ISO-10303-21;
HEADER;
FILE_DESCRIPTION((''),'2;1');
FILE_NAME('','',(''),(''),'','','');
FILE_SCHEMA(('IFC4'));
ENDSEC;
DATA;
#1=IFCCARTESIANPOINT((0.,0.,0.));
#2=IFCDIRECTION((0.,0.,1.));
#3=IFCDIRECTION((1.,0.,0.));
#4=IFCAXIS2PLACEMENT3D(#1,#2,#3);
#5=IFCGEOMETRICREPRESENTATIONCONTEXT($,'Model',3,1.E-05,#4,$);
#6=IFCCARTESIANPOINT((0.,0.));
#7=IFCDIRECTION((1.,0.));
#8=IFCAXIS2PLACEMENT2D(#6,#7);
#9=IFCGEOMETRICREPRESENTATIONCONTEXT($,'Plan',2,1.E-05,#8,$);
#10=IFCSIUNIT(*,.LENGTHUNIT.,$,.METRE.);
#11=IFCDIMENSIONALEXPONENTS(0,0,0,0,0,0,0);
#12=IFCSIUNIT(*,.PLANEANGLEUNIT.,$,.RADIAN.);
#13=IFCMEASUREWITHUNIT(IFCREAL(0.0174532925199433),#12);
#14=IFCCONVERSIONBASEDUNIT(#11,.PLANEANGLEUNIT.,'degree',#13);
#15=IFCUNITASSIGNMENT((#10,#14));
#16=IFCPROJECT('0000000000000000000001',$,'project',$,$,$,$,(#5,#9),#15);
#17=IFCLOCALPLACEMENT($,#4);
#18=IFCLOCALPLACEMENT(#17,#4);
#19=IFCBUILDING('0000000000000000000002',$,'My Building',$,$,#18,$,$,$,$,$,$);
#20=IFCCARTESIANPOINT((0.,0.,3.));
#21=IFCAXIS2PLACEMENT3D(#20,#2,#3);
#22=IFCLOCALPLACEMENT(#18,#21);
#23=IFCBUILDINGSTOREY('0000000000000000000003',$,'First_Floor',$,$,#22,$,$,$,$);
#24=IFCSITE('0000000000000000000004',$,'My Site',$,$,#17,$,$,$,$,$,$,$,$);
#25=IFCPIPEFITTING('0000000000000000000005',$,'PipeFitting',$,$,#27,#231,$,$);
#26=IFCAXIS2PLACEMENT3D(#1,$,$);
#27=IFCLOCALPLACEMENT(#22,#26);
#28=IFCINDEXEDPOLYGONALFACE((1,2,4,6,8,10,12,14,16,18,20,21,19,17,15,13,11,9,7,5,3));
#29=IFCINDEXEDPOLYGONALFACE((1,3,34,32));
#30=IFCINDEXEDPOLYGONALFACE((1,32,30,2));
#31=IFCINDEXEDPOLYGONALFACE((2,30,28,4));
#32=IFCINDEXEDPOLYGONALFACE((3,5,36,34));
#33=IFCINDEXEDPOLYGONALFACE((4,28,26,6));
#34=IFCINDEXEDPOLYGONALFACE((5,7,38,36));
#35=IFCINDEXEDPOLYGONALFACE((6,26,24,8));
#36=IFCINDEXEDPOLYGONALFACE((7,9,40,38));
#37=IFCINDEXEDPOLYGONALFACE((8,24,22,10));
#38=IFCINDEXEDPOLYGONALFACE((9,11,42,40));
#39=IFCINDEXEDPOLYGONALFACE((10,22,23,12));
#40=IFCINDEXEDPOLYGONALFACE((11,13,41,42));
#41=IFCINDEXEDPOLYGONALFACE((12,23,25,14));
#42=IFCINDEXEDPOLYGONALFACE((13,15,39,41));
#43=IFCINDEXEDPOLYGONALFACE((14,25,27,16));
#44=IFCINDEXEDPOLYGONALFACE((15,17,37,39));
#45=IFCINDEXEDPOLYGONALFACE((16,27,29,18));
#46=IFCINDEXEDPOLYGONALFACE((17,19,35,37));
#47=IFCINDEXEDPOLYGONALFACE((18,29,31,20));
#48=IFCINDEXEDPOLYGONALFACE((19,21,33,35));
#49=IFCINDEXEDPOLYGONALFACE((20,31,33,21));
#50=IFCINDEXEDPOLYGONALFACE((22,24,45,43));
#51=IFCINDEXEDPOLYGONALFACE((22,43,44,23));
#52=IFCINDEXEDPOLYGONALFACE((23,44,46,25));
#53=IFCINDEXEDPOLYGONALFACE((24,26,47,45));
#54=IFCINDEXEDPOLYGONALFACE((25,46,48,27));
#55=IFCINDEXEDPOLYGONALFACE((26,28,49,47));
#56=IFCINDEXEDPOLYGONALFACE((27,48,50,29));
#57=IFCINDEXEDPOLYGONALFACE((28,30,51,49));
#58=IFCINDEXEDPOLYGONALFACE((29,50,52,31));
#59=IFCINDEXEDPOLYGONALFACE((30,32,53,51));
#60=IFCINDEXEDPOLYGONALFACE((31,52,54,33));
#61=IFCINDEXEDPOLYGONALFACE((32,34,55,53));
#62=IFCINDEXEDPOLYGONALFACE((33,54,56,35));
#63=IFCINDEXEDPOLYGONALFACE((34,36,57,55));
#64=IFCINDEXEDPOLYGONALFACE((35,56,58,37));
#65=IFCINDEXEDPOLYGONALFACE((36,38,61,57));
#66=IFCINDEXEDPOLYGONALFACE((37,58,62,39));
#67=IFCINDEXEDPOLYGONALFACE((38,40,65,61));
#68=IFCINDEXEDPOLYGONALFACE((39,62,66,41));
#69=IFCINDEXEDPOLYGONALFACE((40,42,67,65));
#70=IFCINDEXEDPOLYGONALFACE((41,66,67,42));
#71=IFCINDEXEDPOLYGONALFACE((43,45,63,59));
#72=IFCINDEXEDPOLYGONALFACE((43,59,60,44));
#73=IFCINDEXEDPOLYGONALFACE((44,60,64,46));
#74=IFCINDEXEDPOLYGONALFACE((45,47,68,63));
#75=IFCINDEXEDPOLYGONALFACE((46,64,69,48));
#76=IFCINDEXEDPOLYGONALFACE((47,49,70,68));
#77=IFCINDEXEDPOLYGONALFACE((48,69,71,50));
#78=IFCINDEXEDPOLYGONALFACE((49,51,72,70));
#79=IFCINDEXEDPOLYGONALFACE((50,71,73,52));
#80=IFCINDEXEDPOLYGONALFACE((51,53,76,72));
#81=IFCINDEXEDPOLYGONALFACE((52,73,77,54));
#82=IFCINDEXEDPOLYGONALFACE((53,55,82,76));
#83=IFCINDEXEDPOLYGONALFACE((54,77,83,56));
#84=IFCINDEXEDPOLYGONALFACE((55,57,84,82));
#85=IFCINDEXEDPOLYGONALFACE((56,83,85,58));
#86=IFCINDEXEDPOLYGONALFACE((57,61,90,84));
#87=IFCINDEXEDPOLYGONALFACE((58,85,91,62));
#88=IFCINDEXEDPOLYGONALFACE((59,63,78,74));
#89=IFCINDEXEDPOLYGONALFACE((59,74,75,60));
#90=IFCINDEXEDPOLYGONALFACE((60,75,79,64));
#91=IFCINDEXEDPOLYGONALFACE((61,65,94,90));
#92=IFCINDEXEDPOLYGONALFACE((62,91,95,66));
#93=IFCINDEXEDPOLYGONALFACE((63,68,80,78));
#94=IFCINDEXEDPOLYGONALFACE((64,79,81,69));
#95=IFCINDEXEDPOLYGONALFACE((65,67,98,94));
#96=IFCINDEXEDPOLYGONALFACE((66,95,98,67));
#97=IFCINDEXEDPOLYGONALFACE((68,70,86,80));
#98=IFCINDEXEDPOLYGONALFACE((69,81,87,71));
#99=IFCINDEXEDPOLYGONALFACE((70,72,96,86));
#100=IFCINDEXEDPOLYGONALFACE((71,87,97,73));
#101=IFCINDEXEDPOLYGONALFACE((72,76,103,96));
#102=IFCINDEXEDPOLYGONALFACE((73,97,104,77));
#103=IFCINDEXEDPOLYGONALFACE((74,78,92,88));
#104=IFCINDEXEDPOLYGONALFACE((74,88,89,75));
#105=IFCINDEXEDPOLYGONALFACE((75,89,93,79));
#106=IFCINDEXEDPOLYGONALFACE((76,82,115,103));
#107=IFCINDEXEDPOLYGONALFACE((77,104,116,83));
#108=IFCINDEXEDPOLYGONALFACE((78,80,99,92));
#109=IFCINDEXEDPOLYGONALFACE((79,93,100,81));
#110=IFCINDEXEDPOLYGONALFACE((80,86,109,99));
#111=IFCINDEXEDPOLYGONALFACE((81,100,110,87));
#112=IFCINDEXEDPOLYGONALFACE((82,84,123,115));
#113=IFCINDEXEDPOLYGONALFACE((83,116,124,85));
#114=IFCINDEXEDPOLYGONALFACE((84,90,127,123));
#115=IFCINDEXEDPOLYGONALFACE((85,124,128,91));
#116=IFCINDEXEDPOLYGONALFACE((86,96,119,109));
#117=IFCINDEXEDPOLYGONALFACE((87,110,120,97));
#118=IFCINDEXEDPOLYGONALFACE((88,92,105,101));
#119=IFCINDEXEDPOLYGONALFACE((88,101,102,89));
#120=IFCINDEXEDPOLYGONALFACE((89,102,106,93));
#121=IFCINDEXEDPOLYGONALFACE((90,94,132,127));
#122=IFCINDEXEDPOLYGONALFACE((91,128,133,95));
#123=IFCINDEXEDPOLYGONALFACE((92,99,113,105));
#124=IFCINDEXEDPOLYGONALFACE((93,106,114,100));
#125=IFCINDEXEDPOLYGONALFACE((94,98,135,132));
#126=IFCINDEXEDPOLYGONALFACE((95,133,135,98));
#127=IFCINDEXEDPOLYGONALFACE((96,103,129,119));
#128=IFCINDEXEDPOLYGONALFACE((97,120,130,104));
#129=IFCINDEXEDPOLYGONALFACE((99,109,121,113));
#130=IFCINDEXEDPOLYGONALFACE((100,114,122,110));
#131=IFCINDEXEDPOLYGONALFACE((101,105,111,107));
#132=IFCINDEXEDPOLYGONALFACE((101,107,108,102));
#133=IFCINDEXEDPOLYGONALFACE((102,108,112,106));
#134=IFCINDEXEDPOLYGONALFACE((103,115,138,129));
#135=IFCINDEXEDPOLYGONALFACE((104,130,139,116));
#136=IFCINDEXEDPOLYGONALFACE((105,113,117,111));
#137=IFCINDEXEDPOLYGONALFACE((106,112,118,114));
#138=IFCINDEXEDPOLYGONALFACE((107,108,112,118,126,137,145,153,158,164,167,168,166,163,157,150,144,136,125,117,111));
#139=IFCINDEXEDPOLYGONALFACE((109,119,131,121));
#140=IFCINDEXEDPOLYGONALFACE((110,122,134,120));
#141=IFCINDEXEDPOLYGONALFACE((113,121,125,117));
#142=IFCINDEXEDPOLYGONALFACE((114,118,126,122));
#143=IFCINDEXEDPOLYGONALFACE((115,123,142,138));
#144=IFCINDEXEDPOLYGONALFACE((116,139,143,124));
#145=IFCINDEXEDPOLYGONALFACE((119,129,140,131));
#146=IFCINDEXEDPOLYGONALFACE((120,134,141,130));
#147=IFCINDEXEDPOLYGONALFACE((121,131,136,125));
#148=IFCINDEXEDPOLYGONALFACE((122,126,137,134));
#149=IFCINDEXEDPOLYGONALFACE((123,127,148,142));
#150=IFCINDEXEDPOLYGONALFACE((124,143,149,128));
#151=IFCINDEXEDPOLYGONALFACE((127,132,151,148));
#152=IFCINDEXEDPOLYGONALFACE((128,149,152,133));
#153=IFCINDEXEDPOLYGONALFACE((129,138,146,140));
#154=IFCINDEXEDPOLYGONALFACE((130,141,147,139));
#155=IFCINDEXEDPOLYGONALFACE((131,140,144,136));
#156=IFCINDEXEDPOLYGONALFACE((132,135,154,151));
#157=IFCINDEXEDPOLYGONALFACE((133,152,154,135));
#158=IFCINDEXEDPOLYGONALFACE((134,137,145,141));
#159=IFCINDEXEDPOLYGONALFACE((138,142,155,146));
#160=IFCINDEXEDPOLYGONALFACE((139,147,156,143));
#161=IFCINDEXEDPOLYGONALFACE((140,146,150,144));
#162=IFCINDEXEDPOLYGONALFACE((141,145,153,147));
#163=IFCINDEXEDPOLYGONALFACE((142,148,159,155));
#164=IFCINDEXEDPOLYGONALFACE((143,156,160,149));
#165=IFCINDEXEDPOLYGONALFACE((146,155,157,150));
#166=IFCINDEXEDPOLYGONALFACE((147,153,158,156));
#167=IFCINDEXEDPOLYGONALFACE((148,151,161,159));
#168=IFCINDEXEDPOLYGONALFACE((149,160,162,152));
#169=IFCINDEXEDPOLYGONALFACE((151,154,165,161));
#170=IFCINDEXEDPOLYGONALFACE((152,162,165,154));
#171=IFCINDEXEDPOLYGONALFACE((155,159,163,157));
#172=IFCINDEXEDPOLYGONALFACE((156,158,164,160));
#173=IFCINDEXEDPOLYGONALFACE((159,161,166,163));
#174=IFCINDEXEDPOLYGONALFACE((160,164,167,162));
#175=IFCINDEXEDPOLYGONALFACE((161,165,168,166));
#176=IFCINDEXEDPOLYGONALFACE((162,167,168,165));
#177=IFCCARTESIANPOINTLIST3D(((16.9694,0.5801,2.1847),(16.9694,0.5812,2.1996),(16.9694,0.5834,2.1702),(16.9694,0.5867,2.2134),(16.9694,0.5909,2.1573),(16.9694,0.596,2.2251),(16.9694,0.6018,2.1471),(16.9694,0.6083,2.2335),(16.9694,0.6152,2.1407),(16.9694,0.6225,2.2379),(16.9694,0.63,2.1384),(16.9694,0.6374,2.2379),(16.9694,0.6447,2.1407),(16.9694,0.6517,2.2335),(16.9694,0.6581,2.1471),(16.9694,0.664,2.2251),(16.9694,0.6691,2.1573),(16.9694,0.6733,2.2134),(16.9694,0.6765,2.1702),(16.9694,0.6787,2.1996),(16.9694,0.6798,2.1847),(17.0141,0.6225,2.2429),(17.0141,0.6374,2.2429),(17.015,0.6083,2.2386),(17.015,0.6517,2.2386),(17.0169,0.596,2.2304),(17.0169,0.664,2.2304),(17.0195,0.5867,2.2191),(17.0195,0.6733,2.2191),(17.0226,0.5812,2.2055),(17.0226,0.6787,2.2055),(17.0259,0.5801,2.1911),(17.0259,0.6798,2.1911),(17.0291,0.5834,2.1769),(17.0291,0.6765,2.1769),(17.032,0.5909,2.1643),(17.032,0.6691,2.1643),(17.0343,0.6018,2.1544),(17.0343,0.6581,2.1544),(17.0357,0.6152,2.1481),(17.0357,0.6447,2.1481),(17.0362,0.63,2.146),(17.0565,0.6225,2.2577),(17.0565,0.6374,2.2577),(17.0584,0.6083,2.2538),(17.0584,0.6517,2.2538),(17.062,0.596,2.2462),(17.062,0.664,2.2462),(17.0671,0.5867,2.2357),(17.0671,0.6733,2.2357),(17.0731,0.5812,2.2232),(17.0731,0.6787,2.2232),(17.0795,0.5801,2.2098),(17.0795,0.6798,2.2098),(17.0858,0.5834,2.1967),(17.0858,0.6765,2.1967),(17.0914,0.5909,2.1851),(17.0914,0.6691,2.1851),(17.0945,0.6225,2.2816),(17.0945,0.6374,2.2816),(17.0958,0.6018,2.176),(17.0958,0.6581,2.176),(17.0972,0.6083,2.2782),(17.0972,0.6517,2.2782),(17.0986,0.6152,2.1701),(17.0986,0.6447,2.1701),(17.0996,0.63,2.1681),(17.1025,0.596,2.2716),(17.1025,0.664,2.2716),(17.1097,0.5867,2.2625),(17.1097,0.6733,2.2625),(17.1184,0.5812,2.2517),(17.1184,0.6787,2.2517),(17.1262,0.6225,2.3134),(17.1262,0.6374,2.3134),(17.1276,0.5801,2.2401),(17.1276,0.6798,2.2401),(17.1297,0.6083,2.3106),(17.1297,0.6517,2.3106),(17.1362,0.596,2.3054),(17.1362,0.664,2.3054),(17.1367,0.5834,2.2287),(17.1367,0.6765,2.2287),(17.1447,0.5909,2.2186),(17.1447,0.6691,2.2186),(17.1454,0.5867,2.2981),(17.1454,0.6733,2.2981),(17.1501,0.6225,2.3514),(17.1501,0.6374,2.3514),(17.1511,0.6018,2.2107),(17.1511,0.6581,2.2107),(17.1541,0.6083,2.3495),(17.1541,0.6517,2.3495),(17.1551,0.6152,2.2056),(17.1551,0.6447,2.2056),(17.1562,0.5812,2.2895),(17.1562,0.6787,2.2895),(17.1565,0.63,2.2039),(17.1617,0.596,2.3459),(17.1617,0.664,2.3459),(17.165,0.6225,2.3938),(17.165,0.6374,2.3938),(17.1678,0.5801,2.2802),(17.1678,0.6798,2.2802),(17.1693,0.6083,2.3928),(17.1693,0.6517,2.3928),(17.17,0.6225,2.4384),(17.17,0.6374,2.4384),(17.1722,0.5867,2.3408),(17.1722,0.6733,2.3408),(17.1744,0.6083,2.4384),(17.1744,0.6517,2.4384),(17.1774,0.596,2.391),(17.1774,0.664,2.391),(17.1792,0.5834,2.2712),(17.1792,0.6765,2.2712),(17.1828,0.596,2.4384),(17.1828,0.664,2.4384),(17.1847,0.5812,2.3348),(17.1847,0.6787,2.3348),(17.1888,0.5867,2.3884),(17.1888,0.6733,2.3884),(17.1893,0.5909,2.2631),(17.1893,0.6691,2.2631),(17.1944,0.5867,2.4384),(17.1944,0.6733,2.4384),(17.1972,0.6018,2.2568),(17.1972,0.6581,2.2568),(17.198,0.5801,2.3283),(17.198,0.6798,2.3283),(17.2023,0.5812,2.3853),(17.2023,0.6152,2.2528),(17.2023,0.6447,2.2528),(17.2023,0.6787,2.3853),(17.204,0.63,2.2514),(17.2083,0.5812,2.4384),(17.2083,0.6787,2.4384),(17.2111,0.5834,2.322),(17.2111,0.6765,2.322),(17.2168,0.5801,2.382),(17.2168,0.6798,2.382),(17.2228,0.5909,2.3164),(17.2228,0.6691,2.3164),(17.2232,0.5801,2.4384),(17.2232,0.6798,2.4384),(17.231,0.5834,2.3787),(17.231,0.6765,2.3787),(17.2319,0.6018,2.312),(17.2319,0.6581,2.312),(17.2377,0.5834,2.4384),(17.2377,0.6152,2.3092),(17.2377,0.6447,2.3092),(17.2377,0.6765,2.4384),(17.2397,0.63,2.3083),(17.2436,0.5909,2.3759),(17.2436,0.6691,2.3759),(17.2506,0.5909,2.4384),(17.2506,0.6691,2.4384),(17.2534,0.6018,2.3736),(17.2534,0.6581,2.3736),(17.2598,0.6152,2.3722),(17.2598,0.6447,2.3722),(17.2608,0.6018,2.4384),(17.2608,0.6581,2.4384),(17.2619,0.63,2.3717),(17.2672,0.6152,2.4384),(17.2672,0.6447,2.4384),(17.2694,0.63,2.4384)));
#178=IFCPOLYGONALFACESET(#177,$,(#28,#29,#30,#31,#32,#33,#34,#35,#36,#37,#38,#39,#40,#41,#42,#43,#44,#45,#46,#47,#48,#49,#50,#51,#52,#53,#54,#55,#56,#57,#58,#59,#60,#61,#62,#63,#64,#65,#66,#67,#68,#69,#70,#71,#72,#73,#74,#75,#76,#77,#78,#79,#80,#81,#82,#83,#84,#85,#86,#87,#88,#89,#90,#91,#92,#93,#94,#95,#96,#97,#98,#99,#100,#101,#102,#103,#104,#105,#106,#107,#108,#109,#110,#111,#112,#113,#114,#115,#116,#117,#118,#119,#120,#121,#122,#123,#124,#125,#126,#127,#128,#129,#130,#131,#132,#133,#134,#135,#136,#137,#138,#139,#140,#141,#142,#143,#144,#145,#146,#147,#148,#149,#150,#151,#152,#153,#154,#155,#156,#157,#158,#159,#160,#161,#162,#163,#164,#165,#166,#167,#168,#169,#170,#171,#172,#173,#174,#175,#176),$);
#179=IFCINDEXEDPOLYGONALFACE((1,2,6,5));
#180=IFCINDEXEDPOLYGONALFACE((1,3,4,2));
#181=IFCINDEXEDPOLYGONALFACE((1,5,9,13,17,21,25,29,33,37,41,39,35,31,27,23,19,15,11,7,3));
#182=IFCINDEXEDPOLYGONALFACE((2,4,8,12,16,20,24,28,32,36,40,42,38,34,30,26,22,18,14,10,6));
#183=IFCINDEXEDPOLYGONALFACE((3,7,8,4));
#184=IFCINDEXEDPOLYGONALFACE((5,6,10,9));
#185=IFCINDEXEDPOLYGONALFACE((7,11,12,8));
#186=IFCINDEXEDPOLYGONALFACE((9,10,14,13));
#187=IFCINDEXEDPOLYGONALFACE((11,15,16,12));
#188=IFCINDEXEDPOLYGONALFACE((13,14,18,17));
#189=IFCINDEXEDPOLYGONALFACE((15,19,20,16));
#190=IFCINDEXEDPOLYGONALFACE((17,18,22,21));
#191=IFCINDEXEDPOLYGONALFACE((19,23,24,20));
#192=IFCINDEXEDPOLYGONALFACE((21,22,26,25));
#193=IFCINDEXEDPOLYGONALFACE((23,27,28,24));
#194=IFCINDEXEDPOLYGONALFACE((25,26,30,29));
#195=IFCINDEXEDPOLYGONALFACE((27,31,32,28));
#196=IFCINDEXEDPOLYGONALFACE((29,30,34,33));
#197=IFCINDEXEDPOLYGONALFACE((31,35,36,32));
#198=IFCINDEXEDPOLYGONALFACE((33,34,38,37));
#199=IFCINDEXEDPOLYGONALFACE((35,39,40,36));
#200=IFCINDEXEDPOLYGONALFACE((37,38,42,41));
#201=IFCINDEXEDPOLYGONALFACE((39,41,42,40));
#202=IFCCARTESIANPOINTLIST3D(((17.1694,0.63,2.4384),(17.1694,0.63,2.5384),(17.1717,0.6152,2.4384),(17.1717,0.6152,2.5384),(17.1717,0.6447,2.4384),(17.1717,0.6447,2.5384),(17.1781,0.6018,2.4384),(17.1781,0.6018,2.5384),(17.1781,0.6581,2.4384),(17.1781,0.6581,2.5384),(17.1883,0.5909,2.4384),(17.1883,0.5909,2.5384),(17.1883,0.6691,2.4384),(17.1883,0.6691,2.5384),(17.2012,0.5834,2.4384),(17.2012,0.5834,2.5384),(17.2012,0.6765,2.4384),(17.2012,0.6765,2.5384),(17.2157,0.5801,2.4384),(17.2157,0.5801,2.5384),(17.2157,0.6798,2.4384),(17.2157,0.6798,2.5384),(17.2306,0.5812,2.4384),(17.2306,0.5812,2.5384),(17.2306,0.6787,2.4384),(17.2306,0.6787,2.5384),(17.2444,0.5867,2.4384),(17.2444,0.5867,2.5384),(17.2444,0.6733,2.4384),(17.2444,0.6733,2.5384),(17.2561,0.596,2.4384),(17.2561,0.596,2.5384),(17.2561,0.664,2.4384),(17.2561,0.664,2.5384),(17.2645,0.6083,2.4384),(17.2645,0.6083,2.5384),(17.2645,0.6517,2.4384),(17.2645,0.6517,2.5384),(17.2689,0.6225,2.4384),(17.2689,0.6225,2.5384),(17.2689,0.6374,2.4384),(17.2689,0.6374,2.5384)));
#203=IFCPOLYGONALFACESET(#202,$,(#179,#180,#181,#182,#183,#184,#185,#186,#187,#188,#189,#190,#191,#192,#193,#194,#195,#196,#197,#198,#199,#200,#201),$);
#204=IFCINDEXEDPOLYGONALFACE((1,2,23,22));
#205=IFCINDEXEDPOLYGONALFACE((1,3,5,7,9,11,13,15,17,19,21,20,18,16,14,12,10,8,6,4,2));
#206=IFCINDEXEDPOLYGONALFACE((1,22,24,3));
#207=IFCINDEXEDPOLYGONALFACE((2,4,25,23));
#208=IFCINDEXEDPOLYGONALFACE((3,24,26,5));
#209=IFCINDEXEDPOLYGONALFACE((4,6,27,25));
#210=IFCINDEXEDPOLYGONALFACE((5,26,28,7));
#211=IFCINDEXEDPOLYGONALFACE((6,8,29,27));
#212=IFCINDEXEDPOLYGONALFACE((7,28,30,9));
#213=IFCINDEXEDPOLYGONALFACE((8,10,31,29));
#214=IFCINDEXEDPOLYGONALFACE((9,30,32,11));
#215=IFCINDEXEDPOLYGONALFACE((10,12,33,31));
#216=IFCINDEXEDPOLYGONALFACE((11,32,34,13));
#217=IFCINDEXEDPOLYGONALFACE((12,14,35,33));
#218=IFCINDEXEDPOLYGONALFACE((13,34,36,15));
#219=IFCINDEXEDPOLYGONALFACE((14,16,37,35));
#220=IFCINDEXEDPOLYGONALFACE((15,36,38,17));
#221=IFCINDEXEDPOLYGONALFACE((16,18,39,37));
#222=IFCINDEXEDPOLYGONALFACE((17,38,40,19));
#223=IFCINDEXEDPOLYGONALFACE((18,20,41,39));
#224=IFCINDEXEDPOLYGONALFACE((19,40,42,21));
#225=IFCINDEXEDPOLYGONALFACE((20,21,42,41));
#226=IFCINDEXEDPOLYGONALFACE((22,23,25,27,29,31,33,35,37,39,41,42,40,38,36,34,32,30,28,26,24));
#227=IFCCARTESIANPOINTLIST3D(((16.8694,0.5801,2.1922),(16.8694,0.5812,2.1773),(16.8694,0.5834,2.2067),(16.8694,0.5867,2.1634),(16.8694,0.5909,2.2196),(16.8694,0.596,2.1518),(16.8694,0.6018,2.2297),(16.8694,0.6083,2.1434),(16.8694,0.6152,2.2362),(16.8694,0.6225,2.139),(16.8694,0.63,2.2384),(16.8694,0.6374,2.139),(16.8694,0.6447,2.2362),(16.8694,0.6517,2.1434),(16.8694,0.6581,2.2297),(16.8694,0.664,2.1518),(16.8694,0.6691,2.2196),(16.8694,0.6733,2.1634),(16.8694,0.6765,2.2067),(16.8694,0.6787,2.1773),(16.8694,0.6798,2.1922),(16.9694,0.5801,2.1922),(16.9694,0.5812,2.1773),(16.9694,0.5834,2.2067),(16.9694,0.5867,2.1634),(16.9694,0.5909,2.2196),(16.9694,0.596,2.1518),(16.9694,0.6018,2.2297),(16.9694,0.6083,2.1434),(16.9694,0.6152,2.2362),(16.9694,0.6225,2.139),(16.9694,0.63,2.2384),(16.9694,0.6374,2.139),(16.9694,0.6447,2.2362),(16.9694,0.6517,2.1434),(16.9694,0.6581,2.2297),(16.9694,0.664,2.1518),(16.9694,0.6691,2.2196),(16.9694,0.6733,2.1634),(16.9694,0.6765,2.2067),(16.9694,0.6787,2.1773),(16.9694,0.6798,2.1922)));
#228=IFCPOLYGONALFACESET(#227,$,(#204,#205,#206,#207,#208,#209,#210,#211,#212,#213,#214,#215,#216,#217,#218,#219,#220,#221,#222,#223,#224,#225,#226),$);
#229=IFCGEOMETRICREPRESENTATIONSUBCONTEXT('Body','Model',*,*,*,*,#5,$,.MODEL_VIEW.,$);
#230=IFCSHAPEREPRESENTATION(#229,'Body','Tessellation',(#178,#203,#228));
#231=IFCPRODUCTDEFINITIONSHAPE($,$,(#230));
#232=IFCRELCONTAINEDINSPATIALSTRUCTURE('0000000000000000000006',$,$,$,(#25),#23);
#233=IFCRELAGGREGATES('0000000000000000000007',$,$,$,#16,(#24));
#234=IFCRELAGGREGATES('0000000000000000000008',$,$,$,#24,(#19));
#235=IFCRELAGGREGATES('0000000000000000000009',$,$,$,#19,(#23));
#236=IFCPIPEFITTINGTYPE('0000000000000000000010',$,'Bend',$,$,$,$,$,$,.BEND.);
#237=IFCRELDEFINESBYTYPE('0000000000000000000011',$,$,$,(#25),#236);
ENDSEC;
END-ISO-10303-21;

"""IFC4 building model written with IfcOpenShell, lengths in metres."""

from ifc_helpers import new_model, entity, si_unit, converted_unit, frame, origin_with_axes, origin_2d_with_axis, place, context, subcontext, project, spatial, circle, extrude, source, transform, mapped, type_object, type_shapes, element, save


model = new_model("IFC4")

# Units and contexts
model_context = context("Model", 3, precision=1e-05, world=origin_with_axes())
plan_context = context("Plan", 2, precision=1e-05, world=origin_2d_with_axis())
body_context = subcontext(model_context, "Body", "Model", "MODEL_VIEW")
ifc_project = project(units=[si_unit("LENGTHUNIT", "METRE"), converted_unit("PLANEANGLEUNIT", "degree", entity("IfcReal", 0.0174532925199433), si_unit("PLANEANGLEUNIT", "RADIAN"), dimensions=[0, 0, 0, 0, 0, 0, 0])], contexts=[model_context, plan_context])

# Site, building, storey
site_placement = place(None, origin_with_axes())
site = spatial("IfcSite", under=ifc_project, at=site_placement, Name="My Site")
building_placement = place(site_placement, origin_with_axes())
building = spatial("IfcBuilding", under=site, at=building_placement, Name="My Building")
storey_placement = place(building_placement, frame((0.0, 0.0, 3.0), z_axis=(0.0, 0.0, 1.0), x_axis=(1.0, 0.0, 0.0)))
storey = spatial("IfcBuildingStorey", under=building, at=storey_placement, Name="First_Floor")

# Pipe fitting
pipe_fitting_type = type_object("IfcPipeFittingType", Name="Bend", PredefinedType="BEND")
shared_shape = source(origin_with_axes(), body_context, "Body", "SolidModel", [
    entity("IfcSweptDiskSolid", entity("IfcIndexedPolyCurve", entity("IfcCartesianPointList3D", [[0.0, 0.0, -0.1], [0.0732, 0.0, -0.2768], [0.25, 0.0, -0.35]]), [entity("IfcArcIndex", [1, 2, 3])]), 0.05),
    extrude(circle(Radius=0.05), origin_with_axes(), (0.0, 0.0, -1.0), 0.1),
    extrude(circle(Radius=0.05), frame((0.25, 0.0, -0.35), z_axis=(1.0, 0.0, 0.0), x_axis=(0.0, 0.0, 1.0)), (0.0, 0.0, 1.0), 0.1),
])
type_shapes(pipe_fitting_type, [shared_shape])
for number, where, z_axis, x_axis, name in (
    (1, (17.2194, 0.63, 2.5384), (0.0, 0.0, 1.0), (-1.0, 0.0, 0.0), "PipeFitting"),
):
    element("IfcPipeFitting", number, at=place(storey_placement, frame(where, z_axis=z_axis, x_axis=x_axis)), inside=storey, type_object=pipe_fitting_type, Name=name, context=body_context, shape_type="MappedRepresentation", body=[
        mapped(shared_shape, transform((0.0, 0.0, 0.0), x_axis=(1.0, 0.0, 0.0), y_axis=(0.0, 1.0, 0.0), z_axis=(0.0, 0.0, 1.0), scale=1.0)),
    ])

save(model, "model.ifc")
